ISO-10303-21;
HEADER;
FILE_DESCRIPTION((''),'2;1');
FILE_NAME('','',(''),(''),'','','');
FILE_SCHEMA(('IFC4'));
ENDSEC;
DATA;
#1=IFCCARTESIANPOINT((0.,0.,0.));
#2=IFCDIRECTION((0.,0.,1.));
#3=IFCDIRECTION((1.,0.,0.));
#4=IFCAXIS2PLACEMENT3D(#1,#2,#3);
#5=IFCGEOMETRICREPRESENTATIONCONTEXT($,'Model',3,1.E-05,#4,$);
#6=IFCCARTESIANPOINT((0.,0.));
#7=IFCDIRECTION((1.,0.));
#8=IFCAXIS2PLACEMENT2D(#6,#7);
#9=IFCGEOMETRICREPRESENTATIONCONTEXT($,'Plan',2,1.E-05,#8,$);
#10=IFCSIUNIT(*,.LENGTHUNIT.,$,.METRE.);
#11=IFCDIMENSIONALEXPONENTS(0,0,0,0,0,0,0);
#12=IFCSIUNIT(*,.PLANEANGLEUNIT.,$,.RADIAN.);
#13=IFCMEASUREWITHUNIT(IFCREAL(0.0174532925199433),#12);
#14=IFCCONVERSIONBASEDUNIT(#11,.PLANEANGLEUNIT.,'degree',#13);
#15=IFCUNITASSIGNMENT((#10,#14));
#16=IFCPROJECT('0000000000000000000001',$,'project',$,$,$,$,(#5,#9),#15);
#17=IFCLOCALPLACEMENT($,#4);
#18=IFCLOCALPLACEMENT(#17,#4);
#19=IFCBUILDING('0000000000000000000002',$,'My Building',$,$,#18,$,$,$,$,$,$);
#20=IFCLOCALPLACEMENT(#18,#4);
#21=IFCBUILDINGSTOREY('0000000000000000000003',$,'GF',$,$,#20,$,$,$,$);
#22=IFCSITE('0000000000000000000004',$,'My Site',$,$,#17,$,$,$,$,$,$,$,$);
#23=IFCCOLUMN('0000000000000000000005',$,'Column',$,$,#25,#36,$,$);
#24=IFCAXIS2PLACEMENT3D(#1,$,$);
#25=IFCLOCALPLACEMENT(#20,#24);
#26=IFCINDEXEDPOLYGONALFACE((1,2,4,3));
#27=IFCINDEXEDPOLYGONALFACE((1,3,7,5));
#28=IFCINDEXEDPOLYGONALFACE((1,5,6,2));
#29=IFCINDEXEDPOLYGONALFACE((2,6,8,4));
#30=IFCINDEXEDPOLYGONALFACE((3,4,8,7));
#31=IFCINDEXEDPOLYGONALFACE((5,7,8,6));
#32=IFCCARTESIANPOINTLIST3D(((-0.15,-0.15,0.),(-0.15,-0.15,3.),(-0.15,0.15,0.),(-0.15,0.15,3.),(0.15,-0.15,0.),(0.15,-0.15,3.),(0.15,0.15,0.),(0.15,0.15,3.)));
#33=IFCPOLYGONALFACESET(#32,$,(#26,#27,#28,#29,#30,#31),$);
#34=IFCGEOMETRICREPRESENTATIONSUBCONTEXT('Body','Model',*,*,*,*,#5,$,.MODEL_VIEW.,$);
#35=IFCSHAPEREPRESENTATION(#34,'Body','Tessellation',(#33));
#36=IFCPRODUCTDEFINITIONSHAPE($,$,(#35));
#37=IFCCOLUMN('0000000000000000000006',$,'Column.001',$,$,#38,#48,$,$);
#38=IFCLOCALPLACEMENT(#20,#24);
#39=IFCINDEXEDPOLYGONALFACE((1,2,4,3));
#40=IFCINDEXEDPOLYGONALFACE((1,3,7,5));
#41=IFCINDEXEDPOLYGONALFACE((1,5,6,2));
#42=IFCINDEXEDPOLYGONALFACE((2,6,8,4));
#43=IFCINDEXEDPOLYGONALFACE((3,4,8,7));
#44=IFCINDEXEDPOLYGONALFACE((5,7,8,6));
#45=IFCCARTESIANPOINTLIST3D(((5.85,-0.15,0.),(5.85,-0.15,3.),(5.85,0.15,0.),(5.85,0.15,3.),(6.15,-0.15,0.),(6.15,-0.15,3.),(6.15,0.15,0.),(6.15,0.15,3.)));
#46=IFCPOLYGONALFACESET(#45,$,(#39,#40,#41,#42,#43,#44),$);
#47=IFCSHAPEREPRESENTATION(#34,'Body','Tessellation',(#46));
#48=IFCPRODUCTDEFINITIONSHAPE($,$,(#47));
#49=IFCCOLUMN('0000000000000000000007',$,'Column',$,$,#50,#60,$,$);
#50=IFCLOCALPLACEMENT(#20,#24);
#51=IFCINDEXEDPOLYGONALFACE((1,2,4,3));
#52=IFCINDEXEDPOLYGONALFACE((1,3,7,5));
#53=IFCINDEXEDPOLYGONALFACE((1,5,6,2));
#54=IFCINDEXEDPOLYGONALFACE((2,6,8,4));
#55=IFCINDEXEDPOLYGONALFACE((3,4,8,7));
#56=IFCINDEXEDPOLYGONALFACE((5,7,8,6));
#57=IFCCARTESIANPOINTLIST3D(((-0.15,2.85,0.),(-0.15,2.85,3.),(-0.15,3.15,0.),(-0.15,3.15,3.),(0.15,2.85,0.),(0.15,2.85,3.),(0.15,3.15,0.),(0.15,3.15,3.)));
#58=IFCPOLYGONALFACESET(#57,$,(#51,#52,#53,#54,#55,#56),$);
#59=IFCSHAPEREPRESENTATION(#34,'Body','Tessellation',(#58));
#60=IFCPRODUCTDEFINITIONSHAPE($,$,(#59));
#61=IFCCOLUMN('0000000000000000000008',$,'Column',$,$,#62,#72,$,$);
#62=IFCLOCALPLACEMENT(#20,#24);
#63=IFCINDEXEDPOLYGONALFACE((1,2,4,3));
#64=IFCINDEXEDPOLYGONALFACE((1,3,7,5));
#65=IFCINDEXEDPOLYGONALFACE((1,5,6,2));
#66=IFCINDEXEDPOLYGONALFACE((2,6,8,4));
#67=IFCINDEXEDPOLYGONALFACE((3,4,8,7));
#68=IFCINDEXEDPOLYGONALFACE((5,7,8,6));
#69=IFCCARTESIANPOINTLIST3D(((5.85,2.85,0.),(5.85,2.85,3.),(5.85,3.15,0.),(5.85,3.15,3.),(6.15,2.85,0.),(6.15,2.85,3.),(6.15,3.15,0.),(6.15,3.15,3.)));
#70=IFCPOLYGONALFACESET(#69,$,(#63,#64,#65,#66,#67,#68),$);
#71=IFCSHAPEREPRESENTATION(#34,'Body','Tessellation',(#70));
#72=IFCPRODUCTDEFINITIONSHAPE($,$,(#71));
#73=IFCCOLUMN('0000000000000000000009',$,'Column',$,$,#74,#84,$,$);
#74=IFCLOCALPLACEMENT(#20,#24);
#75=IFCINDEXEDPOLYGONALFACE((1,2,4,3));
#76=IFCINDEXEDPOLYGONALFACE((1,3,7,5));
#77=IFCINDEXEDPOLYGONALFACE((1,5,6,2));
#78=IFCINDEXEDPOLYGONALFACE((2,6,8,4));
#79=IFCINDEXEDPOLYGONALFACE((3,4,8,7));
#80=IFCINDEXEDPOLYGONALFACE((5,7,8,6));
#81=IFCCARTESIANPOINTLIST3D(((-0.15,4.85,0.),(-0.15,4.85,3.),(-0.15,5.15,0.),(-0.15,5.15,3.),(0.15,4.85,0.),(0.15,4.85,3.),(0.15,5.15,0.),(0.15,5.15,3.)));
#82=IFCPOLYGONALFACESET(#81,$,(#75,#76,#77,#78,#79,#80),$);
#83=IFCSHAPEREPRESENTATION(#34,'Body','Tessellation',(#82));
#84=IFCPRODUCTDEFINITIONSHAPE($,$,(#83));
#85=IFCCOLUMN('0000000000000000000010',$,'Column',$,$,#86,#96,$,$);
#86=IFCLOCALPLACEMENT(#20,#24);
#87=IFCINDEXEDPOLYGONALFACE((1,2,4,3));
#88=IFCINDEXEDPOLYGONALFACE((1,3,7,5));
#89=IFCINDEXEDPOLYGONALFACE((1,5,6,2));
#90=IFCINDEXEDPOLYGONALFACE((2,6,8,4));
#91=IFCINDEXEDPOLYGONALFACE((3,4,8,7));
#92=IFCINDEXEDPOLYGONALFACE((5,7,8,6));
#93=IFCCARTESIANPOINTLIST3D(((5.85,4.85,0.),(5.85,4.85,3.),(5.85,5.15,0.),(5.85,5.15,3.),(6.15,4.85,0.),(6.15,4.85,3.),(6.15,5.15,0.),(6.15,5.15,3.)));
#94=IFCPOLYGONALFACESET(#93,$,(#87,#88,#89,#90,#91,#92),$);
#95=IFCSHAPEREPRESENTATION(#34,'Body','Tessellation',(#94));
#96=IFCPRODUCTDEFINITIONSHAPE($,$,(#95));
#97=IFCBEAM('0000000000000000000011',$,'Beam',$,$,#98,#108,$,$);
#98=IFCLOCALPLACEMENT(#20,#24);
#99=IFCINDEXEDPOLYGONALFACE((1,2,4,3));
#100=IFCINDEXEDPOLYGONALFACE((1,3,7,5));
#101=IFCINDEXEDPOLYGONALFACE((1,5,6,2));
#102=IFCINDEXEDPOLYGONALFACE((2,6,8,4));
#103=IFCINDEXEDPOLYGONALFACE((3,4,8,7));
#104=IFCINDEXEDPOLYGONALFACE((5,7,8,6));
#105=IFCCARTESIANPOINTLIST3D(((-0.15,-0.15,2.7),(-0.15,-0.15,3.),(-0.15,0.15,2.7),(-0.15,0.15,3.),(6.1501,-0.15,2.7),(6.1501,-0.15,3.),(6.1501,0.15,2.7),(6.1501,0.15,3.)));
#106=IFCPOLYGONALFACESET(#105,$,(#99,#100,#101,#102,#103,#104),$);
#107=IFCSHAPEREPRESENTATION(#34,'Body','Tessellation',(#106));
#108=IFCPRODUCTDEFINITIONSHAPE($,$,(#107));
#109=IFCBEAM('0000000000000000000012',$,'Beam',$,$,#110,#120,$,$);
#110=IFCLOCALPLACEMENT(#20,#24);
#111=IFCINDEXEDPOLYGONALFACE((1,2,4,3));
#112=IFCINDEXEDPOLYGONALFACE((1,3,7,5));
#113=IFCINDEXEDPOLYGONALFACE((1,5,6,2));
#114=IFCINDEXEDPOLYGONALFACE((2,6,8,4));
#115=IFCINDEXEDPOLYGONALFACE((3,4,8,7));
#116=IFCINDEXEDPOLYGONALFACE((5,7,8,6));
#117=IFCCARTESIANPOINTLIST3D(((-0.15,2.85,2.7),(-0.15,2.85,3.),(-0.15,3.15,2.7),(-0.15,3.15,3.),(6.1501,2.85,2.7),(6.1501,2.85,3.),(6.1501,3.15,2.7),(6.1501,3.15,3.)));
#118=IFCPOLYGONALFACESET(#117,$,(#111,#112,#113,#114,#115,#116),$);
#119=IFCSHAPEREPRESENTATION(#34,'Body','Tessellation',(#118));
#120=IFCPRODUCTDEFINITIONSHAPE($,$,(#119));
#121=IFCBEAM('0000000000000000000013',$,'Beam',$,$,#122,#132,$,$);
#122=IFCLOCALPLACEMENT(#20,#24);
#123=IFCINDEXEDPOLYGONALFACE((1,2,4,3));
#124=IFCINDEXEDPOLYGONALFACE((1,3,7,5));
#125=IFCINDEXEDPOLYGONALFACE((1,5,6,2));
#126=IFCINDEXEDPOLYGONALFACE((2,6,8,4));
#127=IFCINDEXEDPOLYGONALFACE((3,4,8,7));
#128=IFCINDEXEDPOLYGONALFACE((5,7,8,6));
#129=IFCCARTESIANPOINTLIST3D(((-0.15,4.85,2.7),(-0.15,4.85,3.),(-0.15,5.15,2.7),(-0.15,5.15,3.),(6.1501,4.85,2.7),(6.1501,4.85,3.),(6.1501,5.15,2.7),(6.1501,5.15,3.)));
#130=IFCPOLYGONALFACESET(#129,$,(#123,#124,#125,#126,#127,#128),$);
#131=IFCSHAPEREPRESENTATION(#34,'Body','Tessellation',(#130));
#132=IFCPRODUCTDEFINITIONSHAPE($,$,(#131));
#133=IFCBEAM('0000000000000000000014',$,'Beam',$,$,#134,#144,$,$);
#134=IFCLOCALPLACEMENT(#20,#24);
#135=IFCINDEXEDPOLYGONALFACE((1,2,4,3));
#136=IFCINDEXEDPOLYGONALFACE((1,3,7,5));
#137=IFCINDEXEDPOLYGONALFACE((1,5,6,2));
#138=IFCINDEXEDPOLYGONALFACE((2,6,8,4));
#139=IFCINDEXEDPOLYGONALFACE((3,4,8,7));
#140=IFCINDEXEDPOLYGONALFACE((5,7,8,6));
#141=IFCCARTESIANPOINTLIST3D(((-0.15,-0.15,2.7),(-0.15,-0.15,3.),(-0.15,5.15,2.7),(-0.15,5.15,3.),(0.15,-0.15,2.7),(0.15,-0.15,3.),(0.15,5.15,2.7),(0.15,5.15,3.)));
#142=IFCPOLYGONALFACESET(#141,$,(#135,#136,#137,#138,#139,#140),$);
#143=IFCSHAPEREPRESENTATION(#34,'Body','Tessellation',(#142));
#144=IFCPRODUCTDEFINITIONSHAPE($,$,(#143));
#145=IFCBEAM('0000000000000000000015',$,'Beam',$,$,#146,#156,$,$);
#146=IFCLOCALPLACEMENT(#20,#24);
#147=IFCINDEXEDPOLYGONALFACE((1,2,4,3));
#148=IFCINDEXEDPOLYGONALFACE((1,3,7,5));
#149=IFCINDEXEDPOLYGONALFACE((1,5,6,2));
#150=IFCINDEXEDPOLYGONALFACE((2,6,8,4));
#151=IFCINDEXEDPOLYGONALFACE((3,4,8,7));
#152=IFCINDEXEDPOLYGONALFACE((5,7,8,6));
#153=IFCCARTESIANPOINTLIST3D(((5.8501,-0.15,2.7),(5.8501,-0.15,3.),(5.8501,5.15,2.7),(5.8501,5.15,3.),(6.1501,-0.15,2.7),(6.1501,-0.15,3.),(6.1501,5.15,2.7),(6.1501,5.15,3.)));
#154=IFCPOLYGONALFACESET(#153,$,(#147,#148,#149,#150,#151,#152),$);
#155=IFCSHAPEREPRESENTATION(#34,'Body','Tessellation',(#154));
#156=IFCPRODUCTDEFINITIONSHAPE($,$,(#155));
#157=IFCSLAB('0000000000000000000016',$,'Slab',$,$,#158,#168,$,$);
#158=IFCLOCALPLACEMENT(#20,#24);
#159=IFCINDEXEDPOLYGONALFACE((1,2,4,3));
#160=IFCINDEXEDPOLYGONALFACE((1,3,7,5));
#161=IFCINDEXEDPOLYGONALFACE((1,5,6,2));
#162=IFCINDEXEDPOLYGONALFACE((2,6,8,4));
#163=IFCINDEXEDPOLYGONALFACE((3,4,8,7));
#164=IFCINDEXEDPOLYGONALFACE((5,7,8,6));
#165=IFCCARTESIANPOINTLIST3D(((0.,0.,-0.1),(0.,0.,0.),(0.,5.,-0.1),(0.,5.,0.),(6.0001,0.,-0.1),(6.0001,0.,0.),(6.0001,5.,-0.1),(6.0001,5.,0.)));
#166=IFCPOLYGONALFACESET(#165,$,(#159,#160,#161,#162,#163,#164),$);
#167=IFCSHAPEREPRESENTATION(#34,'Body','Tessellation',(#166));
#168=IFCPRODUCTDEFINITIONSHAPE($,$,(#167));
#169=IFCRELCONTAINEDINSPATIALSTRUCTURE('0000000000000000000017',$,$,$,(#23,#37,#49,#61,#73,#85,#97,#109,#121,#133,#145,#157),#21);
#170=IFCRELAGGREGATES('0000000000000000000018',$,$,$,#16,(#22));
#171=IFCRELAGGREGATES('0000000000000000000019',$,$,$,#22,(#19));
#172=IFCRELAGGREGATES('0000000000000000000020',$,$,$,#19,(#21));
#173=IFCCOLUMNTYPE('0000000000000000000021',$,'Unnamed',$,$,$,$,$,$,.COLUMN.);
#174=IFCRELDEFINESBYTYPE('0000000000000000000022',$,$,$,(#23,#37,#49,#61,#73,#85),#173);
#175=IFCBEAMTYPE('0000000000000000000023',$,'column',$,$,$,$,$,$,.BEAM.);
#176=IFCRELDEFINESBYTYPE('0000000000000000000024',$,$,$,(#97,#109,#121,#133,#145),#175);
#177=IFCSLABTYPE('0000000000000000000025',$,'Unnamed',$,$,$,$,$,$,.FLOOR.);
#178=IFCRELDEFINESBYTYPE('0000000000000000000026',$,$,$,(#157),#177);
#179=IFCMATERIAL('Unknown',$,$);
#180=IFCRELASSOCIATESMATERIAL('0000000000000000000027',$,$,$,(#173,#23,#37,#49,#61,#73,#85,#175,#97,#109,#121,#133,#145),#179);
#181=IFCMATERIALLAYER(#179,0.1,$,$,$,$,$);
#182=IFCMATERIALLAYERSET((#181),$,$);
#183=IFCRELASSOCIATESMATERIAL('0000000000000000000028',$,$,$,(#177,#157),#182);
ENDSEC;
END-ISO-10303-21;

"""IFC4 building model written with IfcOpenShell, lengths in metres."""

from ifc_helpers import new_model, entity, si_unit, converted_unit, frame, origin_with_axes, origin_2d_with_axis, place, context, subcontext, project, spatial, indexed_curve, rectangle, outline, extrude, material, layer, layer_set, layer_usage, material_profile, profile_set, profile_usage, type_object, element, save


model = new_model("IFC4")

# Units and contexts
model_context = context("Model", 3, precision=1e-05, world=origin_with_axes())
plan_context = context("Plan", 2, precision=1e-05, world=origin_2d_with_axis())
body_context_1 = subcontext(model_context, "Body", "Model", "MODEL_VIEW")
ifc_project = project(units=[si_unit("LENGTHUNIT", "METRE"), converted_unit("PLANEANGLEUNIT", "degree", entity("IfcReal", 0.0174532925199433), si_unit("PLANEANGLEUNIT", "RADIAN"), dimensions=[0, 0, 0, 0, 0, 0, 0])], contexts=[model_context, plan_context])

# Site, building, storey
site_placement = place(None, origin_with_axes())
site = spatial("IfcSite", under=ifc_project, at=site_placement, Name="My Site")
building_placement = place(site_placement, origin_with_axes())
building = spatial("IfcBuilding", under=site, at=building_placement, Name="My Building")
storey_placement = place(building_placement, origin_with_axes())
storey = spatial("IfcBuildingStorey", under=building, at=storey_placement, Name="GF")

# Columns
ifc_material = material(Name="Unknown")
ifc_material_profile_1 = material_profile(ifc_material, rectangle(XDim=0.3, YDim=0.3))
ifc_profile_set_1 = profile_set([ifc_material_profile_1])
ifc_profile_usage_1 = profile_usage(ifc_profile_set_1, cardinal=5)
column_type = type_object("IfcColumnType", Name="Unnamed", PredefinedType="COLUMN", material=ifc_profile_set_1)
column_1_placement = place(storey_placement, origin_with_axes())
element("IfcColumn", 1, at=column_1_placement, inside=storey, type_object=column_type, material=ifc_profile_usage_1, Name="Column", context=body_context_1, shape_type="SweptSolid", body=[
    extrude(rectangle(XDim=0.3, YDim=0.3), origin_with_axes(), (0.0, 0.0, 1.0), 3.0),
])
ifc_profile_usage_2 = profile_usage(ifc_profile_set_1, cardinal=5)
column_2_placement = place(storey_placement, frame((6.0, 0.0, 0.0), z_axis=(0.0, 0.0, 1.0), x_axis=(1.0, 0.0, 0.0)))
element("IfcColumn", 2, at=column_2_placement, inside=storey, type_object=column_type, material=ifc_profile_usage_2, Name="Column.001", context=body_context_1, shape_type="SweptSolid", body=[
    extrude(rectangle(XDim=0.3, YDim=0.3), origin_with_axes(), (0.0, 0.0, 1.0), 3.0),
])
ifc_profile_usage_3 = profile_usage(ifc_profile_set_1, cardinal=5)
column_3_placement = place(storey_placement, frame((0.0, 3.0, 0.0), z_axis=(0.0, 0.0, 1.0), x_axis=(1.0, 0.0, 0.0)))
element("IfcColumn", 3, at=column_3_placement, inside=storey, type_object=column_type, material=ifc_profile_usage_3, Name="Column", context=body_context_1, shape_type="SweptSolid", body=[
    extrude(rectangle(XDim=0.3, YDim=0.3), origin_with_axes(), (0.0, 0.0, 1.0), 3.0),
])
ifc_profile_usage_4 = profile_usage(ifc_profile_set_1, cardinal=5)
column_4_placement = place(storey_placement, frame((6.0, 3.0, 0.0), z_axis=(0.0, 0.0, 1.0), x_axis=(1.0, 0.0, 0.0)))
element("IfcColumn", 4, at=column_4_placement, inside=storey, type_object=column_type, material=ifc_profile_usage_4, Name="Column", context=body_context_1, shape_type="SweptSolid", body=[
    extrude(rectangle(XDim=0.3, YDim=0.3), origin_with_axes(), (0.0, 0.0, 1.0), 3.0),
])
ifc_profile_usage_5 = profile_usage(ifc_profile_set_1, cardinal=5)
column_5_placement = place(storey_placement, frame((0.0, 5.0, 0.0), z_axis=(0.0, 0.0, 1.0), x_axis=(1.0, 0.0, 0.0)))
element("IfcColumn", 5, at=column_5_placement, inside=storey, type_object=column_type, material=ifc_profile_usage_5, Name="Column", context=body_context_1, shape_type="SweptSolid", body=[
    extrude(rectangle(XDim=0.3, YDim=0.3), origin_with_axes(), (0.0, 0.0, 1.0), 3.0),
])
ifc_profile_usage_6 = profile_usage(ifc_profile_set_1, cardinal=5)
column_6_placement = place(storey_placement, frame((6.0, 5.0, 0.0), z_axis=(0.0, 0.0, 1.0), x_axis=(1.0, 0.0, 0.0)))
element("IfcColumn", 6, at=column_6_placement, inside=storey, type_object=column_type, material=ifc_profile_usage_6, Name="Column", context=body_context_1, shape_type="SweptSolid", body=[
    extrude(rectangle(XDim=0.3, YDim=0.3), origin_with_axes(), (0.0, 0.0, 1.0), 3.0),
])

# Beams
ifc_material_profile_2 = material_profile(ifc_material, rectangle(XDim=0.3, YDim=0.3))
ifc_profile_set_2 = profile_set([ifc_material_profile_2])
ifc_profile_usage_7 = profile_usage(ifc_profile_set_2, cardinal=5)
beam_type = type_object("IfcBeamType", Name="column", PredefinedType="BEAM", material=ifc_profile_set_2)
beam_1_placement = place(storey_placement, frame((-0.15, 0.0, 2.85), z_axis=(1.0, 0.0, 0.0), x_axis=(0.0, 1.0, 0.0)))
element("IfcBeam", 7, at=beam_1_placement, inside=storey, type_object=beam_type, material=ifc_profile_usage_7, Name="Beam", context=body_context_1, shape_type="SweptSolid", body=[
    extrude(rectangle(XDim=0.3, YDim=0.3), origin_with_axes(), (0.0, 0.0, 1.0), 6.3001),
])
ifc_profile_usage_8 = profile_usage(ifc_profile_set_2, cardinal=5)
beam_2_placement = place(storey_placement, frame((-0.15, 3.0, 2.85), z_axis=(1.0, 0.0, 0.0), x_axis=(0.0, 1.0, 0.0)))
element("IfcBeam", 8, at=beam_2_placement, inside=storey, type_object=beam_type, material=ifc_profile_usage_8, Name="Beam", context=body_context_1, shape_type="SweptSolid", body=[
    extrude(rectangle(XDim=0.3, YDim=0.3), origin_with_axes(), (0.0, 0.0, 1.0), 6.3001),
])
ifc_profile_usage_9 = profile_usage(ifc_profile_set_2, cardinal=5)
beam_3_placement = place(storey_placement, frame((-0.15, 5.0, 2.85), z_axis=(1.0, 0.0, 0.0), x_axis=(0.0, 1.0, 0.0)))
element("IfcBeam", 9, at=beam_3_placement, inside=storey, type_object=beam_type, material=ifc_profile_usage_9, Name="Beam", context=body_context_1, shape_type="SweptSolid", body=[
    extrude(rectangle(XDim=0.3, YDim=0.3), origin_with_axes(), (0.0, 0.0, 1.0), 6.3001),
])
ifc_profile_usage_10 = profile_usage(ifc_profile_set_2, cardinal=5)
beam_4_placement = place(storey_placement, frame((0.0, 5.15, 2.85), z_axis=(0.0, -1.0, 0.0), x_axis=(1.0, 0.0, 0.0)))
element("IfcBeam", 10, at=beam_4_placement, inside=storey, type_object=beam_type, material=ifc_profile_usage_10, Name="Beam", context=body_context_1, shape_type="SweptSolid", body=[
    extrude(rectangle(XDim=0.3, YDim=0.3), origin_with_axes(), (0.0, 0.0, 1.0), 5.3),
])
ifc_profile_usage_11 = profile_usage(ifc_profile_set_2, cardinal=5)
beam_5_placement = place(storey_placement, frame((6.0001, 5.15, 2.85), z_axis=(0.0, -1.0, 0.0), x_axis=(1.0, 0.0, 0.0)))
element("IfcBeam", 11, at=beam_5_placement, inside=storey, type_object=beam_type, material=ifc_profile_usage_11, Name="Beam", context=body_context_1, shape_type="SweptSolid", body=[
    extrude(rectangle(XDim=0.3, YDim=0.3), origin_with_axes(), (0.0, 0.0, 1.0), 5.3),
])

# Slab
ifc_layer_1 = layer(ifc_material, 0.1)
ifc_layer_set_1 = layer_set([ifc_layer_1])
ifc_layer_usage_1 = layer_usage(ifc_layer_set_1, "AXIS3", "POSITIVE", -0.1)
slab_type = type_object("IfcSlabType", Name="Unnamed", PredefinedType="FLOOR", material=ifc_layer_set_1)
slab_placement = place(storey_placement, frame((0.0, 5.0, 0.0), z_axis=(0.0, 0.0, 1.0), x_axis=(1.0, 0.0, 0.0)))
element("IfcSlab", 12, at=slab_placement, inside=storey, type_object=slab_type, material=ifc_layer_usage_1, Name="Slab", context=body_context_1, shape_type="SweptSolid", body=[
    extrude(outline(indexed_curve([(0.0, 0.0), (6.0001, 0.0), (6.0001, -5.0), (0.0, -5.0), (0.0, 0.0)])), frame((0.0, 0.0, -0.1), z_axis=(0.0, 0.0, 1.0), x_axis=(1.0, 0.0, 0.0)), (0.0, 0.0, 1.0), 0.1),
])

save(model, "model.ifc")
